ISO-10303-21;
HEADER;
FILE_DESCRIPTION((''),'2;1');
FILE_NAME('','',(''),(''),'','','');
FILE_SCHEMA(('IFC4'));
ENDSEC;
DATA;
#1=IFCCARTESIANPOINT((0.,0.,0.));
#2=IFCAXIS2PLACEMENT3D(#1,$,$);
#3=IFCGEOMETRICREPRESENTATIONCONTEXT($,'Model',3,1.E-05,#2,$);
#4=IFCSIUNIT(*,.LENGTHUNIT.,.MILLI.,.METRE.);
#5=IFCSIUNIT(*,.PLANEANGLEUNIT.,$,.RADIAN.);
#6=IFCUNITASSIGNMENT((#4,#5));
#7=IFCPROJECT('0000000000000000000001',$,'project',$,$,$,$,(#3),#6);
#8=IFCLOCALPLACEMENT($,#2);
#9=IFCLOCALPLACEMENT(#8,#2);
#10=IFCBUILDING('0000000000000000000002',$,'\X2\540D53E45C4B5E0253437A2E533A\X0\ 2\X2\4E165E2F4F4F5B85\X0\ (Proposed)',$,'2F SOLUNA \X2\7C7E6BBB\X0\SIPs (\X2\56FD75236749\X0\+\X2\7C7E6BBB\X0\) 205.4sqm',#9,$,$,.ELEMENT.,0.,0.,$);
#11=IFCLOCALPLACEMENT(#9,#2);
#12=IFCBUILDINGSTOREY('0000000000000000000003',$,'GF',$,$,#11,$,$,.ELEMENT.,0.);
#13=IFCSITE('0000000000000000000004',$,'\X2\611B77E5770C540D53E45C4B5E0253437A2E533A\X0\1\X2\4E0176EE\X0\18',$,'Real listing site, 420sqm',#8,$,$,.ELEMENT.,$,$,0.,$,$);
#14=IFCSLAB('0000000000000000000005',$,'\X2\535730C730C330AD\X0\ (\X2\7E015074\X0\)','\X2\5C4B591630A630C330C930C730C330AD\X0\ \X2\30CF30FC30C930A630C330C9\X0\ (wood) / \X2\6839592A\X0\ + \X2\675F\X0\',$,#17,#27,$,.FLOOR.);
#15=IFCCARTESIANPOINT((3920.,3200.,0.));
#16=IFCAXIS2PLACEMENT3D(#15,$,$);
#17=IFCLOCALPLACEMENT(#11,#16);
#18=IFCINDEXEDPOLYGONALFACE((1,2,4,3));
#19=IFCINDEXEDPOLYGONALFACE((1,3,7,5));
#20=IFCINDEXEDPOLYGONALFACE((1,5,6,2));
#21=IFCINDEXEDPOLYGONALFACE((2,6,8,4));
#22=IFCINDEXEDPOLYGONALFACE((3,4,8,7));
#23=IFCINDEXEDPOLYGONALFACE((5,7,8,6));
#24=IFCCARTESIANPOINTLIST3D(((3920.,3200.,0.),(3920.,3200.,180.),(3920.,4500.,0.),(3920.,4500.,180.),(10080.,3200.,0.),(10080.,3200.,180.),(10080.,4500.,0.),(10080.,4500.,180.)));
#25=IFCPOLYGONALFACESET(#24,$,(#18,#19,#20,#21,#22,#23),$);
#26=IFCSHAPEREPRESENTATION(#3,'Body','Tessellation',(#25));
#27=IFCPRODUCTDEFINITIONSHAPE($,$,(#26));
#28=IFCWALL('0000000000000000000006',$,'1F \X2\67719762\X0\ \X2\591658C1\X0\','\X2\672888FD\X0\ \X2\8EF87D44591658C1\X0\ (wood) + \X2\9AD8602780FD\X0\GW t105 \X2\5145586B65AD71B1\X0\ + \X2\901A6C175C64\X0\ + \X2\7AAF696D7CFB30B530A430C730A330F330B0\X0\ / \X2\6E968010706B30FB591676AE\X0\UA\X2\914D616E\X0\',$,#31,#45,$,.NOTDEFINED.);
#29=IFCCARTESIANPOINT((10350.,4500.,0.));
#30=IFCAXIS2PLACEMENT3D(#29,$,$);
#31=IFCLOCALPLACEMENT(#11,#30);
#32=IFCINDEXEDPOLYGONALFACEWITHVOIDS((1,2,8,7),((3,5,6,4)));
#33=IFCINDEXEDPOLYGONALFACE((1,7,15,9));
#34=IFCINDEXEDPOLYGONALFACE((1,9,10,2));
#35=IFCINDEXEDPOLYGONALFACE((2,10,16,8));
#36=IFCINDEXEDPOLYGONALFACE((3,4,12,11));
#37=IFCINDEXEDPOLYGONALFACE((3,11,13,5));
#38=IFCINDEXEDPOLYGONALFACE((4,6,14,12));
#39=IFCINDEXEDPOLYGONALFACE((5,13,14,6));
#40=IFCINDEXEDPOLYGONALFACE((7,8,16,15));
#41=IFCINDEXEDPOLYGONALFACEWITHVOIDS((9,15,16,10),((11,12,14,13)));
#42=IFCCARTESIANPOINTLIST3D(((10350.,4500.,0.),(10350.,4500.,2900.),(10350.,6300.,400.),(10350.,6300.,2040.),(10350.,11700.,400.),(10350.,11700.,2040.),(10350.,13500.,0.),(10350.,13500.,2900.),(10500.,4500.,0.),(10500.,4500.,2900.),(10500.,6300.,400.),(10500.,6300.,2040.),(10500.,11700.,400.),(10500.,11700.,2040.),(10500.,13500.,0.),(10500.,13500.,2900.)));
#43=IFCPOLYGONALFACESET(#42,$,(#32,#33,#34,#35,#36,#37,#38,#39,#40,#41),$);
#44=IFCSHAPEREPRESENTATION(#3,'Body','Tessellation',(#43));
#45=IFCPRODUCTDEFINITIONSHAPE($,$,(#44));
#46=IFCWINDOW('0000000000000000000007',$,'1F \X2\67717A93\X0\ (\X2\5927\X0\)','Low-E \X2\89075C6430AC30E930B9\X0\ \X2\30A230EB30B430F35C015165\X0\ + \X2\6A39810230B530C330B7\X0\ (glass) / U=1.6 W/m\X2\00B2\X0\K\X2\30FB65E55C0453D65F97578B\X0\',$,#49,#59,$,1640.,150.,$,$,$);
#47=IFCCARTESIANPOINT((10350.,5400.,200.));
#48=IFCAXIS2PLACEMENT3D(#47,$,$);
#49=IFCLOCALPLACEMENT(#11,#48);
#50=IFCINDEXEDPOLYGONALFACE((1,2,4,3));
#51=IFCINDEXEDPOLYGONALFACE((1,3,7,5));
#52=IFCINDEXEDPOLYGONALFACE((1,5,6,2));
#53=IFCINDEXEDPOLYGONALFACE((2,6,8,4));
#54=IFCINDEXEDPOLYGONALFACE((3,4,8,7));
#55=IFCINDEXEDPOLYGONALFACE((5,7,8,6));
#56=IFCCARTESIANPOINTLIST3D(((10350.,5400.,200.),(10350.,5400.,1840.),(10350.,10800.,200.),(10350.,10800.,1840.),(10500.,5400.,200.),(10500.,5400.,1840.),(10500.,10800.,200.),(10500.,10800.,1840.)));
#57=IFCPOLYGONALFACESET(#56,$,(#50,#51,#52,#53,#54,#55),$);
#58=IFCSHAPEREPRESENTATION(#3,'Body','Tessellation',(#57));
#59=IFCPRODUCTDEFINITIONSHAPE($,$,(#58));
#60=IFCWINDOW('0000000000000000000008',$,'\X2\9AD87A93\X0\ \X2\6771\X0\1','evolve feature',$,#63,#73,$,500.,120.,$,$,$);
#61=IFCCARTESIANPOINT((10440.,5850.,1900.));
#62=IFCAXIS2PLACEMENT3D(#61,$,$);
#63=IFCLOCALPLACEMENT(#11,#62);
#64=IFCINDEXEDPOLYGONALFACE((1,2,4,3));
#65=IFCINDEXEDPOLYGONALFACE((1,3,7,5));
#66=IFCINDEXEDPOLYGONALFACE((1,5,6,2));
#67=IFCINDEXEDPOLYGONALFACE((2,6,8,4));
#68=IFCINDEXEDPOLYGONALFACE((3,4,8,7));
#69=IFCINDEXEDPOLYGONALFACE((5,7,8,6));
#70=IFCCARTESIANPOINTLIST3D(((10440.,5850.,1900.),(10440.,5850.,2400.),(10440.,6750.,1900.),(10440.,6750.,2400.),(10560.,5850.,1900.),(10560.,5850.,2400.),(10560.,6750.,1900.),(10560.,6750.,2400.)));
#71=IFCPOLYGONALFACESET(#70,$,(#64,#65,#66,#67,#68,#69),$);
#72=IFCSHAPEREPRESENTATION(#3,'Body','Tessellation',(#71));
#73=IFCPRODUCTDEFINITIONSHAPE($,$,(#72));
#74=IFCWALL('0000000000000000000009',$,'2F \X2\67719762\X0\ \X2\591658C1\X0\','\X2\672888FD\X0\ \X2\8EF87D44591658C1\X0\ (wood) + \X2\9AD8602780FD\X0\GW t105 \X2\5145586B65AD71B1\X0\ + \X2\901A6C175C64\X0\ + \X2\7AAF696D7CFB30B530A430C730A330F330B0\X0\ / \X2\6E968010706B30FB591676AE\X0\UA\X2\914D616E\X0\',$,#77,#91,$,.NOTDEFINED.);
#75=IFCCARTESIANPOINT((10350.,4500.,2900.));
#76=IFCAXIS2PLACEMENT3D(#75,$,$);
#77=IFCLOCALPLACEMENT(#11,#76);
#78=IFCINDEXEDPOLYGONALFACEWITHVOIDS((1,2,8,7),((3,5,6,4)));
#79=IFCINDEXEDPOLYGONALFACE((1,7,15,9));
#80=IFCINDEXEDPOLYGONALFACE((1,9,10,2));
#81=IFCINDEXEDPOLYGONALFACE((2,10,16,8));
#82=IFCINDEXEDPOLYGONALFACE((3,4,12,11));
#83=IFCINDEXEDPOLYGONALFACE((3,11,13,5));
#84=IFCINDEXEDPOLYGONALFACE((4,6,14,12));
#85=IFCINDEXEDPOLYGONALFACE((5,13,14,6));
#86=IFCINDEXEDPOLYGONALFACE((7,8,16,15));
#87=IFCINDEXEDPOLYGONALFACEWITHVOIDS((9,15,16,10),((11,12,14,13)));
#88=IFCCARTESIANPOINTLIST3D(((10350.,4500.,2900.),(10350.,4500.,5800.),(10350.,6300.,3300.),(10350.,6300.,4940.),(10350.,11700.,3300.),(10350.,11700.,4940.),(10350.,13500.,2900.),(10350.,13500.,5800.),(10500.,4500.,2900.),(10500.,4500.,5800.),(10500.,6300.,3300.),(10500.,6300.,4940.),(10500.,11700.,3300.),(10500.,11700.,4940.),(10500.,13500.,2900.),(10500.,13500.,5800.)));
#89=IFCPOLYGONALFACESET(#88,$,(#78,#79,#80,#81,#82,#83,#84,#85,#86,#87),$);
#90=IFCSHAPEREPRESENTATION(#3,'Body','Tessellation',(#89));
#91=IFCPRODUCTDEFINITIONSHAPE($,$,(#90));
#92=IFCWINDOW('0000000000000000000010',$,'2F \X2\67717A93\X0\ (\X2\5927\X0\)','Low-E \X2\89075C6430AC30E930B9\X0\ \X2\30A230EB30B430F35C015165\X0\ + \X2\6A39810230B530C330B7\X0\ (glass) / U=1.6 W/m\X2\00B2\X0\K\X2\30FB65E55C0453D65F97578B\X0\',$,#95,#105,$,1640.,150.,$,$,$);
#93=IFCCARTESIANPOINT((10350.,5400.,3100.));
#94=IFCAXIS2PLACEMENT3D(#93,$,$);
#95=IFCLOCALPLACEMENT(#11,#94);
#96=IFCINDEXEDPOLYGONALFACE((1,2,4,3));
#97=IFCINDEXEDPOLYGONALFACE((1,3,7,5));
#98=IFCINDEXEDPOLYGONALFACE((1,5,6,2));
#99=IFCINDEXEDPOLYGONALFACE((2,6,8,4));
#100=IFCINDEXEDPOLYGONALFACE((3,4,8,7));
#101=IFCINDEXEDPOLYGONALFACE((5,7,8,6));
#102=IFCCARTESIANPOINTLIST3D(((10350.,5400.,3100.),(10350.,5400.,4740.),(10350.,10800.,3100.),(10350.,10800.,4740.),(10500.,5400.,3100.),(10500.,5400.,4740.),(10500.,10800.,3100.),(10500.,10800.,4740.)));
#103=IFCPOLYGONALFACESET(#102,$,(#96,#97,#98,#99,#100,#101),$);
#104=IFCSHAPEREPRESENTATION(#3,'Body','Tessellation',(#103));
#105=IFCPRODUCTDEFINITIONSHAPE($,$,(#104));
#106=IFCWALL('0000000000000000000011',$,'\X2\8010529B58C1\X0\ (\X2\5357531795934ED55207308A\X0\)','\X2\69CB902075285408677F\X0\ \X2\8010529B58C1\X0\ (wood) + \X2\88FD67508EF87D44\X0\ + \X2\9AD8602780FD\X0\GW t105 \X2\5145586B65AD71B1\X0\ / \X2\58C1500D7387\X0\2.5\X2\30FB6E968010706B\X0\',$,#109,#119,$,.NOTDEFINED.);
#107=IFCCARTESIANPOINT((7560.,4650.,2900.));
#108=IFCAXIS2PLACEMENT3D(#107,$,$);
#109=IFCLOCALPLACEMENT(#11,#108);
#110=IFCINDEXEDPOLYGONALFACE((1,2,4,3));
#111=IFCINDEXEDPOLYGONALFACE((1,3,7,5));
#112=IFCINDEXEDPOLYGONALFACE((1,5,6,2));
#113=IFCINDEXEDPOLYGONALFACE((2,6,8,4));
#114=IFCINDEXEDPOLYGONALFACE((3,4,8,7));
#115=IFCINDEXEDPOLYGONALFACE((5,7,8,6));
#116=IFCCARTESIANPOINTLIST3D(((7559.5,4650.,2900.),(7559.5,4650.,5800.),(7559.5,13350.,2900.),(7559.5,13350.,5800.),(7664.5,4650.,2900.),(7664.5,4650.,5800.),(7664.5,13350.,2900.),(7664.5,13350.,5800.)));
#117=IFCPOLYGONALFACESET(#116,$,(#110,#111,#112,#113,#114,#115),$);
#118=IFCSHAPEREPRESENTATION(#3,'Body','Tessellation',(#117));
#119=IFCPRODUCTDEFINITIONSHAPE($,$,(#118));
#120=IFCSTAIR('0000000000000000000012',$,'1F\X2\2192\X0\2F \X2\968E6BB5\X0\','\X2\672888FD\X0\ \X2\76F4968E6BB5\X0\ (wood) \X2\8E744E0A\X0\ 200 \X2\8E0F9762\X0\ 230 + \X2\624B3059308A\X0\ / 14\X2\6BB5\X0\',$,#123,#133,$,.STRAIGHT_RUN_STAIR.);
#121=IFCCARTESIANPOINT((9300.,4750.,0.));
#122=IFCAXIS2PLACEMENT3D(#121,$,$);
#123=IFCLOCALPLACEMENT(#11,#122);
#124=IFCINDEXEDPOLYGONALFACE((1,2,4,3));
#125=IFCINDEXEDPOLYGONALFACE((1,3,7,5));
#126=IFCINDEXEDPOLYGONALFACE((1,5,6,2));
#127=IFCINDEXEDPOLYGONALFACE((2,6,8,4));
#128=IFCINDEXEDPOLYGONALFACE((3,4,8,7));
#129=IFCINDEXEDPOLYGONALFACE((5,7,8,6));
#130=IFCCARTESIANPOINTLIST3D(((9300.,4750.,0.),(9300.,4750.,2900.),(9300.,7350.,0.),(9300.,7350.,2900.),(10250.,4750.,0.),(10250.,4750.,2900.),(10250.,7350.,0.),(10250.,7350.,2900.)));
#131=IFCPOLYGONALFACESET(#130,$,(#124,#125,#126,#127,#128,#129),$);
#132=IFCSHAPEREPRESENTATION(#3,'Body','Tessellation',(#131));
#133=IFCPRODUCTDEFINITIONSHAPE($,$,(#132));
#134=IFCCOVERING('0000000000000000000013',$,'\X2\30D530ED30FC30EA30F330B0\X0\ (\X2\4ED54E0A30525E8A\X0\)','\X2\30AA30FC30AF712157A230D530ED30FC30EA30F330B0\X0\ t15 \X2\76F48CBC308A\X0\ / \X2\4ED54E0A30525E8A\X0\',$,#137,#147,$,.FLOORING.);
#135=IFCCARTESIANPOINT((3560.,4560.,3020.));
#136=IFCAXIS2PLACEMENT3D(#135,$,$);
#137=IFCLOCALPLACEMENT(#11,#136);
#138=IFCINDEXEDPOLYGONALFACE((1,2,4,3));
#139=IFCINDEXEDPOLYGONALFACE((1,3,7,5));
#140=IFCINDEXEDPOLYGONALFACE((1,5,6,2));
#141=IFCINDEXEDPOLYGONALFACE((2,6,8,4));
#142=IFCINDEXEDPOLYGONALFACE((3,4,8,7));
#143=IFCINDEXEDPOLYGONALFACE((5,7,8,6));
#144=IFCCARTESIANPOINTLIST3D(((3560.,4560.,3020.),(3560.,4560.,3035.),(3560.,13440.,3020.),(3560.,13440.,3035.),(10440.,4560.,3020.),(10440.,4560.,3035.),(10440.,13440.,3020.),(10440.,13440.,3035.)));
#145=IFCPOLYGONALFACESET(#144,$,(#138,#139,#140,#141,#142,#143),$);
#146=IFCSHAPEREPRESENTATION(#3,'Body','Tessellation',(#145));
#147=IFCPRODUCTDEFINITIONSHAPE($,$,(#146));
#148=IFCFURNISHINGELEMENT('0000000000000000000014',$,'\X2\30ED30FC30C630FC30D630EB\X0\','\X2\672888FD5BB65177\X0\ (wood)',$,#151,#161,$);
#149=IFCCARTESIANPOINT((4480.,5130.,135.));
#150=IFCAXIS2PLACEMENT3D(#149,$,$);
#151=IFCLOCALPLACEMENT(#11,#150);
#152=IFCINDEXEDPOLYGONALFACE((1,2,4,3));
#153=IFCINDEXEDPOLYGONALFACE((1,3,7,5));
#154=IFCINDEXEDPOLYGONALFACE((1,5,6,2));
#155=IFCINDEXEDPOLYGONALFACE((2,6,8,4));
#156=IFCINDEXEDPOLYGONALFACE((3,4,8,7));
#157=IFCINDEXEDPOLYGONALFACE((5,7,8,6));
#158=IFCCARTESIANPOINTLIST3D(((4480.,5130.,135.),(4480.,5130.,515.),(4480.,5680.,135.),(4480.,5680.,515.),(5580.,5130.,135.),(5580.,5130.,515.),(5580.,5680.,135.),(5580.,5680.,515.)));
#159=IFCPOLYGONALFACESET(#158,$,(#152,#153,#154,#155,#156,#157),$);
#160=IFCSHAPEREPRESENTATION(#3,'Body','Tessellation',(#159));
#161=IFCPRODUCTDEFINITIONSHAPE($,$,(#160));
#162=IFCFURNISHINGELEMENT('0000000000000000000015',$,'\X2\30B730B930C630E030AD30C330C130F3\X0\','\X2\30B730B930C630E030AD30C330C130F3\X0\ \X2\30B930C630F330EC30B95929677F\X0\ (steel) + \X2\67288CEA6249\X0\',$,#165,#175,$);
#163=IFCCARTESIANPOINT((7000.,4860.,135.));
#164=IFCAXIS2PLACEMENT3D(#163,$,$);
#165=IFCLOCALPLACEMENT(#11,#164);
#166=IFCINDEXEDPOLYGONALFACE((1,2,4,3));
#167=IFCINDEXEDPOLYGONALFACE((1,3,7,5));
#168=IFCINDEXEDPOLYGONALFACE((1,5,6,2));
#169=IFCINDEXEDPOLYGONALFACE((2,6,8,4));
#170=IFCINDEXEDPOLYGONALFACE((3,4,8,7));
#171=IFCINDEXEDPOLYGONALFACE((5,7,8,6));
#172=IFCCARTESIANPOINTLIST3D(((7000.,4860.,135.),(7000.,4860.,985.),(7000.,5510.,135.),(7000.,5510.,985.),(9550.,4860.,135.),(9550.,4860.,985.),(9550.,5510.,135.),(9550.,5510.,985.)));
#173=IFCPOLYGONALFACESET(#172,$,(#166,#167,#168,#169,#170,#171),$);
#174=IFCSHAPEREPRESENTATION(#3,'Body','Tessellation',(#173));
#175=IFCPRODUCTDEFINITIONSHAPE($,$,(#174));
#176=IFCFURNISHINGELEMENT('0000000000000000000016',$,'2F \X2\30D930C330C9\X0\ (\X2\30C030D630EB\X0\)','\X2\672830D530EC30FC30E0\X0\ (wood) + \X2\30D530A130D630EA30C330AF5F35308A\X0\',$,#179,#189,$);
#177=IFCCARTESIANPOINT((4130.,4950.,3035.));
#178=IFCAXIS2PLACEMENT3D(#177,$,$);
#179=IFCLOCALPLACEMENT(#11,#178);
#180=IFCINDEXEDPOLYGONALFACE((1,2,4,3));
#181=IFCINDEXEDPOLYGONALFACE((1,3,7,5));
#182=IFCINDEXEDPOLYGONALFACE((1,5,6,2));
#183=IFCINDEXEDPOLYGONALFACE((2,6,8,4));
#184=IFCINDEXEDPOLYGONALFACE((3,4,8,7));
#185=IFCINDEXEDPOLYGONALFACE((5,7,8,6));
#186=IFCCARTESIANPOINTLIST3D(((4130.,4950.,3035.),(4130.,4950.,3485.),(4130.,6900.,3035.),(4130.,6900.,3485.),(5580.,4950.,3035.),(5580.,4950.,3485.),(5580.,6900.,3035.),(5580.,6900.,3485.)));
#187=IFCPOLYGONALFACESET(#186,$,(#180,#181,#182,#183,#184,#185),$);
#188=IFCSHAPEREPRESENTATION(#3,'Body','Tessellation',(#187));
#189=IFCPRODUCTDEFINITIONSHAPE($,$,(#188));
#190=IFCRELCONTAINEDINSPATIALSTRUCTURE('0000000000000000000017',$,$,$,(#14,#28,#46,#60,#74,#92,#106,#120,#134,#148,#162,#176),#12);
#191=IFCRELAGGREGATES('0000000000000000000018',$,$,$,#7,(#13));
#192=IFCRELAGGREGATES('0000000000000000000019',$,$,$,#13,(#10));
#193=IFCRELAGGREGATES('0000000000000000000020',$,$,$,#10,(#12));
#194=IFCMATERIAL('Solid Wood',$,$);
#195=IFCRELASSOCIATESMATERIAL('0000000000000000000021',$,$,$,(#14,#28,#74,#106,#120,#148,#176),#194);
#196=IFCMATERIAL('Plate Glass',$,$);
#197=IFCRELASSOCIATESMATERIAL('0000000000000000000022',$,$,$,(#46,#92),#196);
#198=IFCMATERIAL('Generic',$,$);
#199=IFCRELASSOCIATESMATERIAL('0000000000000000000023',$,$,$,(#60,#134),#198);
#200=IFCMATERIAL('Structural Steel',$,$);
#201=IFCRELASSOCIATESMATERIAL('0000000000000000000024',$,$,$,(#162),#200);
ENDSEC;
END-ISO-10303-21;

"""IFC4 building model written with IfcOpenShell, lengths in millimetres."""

from ifc_helpers import new_model, si_unit, frame, frame_2d, origin, place, context, project, spatial, rectangle, extrude, material, element, fill, save


model = new_model("IFC4")

# Units and contexts
model_context = context("Model", 3, precision=1e-05, world=origin())
ifc_project = project(units=[si_unit("LENGTHUNIT", "METRE", prefix="MILLI"), si_unit("PLANEANGLEUNIT", "RADIAN")], contexts=[model_context])

# Site, building, storey
site_placement = place(None, origin())
site = spatial("IfcSite", under=ifc_project, at=site_placement, Name="愛知県名古屋市千種区1丁目18", ObjectType="Real listing site, 420sqm", CompositionType="ELEMENT", RefElevation=0.0)
building_placement = place(site_placement, origin())
building = spatial("IfcBuilding", under=site, at=building_placement, Name="名古屋市千種区 2世帯住宅 (Proposed)", ObjectType="2F SOLUNA 籾殻SIPs (国産杉+籾殻) 205.4sqm", CompositionType="ELEMENT", ElevationOfRefHeight=0.0, ElevationOfTerrain=0.0)
storey_placement = place(building_placement, origin())
storey = spatial("IfcBuildingStorey", under=building, at=storey_placement, Name="GF", CompositionType="ELEMENT", Elevation=0.0)

# Slab
ifc_material_1 = material(Name="Solid Wood")
slab_placement = place(storey_placement, frame((3920.0, 3200.0, 0.0)))
element("IfcSlab", 1, at=slab_placement, inside=storey, material=ifc_material_1, Name="南デッキ (縁側)", Description="屋外ウッドデッキ ハードウッド (wood) / 根太 + 束", PredefinedType="FLOOR", context=model_context, shape_type="SweptSolid", body=[
    extrude(rectangle(XDim=6160.0, YDim=1300.0, at=frame_2d((3080.0, 650.0))), frame((3920.0, 3200.0, 0.0)), (0.0, 0.0, 1.0), 180.0),
])

# Wall, openings, windows
wall_1_placement = place(storey_placement, frame((10350.0, 4500.0, 0.0)))
wall_1 = element("IfcWall", 2, at=wall_1_placement, inside=storey, material=ifc_material_1, Name="1F 東面 外壁", Description="木製 軸組外壁 (wood) + 高性能GW t105 充填断熱 + 通気層 + 窯業系サイディング / 準耐火・外皮UA配慮", PredefinedType="NOTDEFINED", context=model_context, shape_type="SweptSolid", body=[
    extrude(rectangle(XDim=150.0, YDim=9000.0, at=frame_2d((75.0, 4500.0))), frame((10350.0, 4500.0, 0.0)), (0.0, 0.0, 1.0), 2900.0),
])
opening_1_placement = place(storey_placement, frame((10350.0, 5400.0, 200.0)))
opening_1 = element("IfcOpeningElement", 3, at=opening_1_placement, cuts=wall_1, PredefinedType="NOTDEFINED", context=model_context, shape_type="SweptSolid", body=[
    extrude(rectangle(XDim=150.0, YDim=5400.0, at=frame_2d((75.0, 2700.0))), frame((10350.0, 5400.0, 200.0)), (0.0, 0.0, 1.0), 1640.0),
])
opening_2_placement = place(storey_placement, frame((10440.0, 5850.0, 1900.0)))
opening_2 = element("IfcOpeningElement", 4, at=opening_2_placement, cuts=wall_1, PredefinedType="NOTDEFINED", context=model_context, shape_type="SweptSolid", body=[
    extrude(rectangle(XDim=120.0, YDim=900.0, at=frame_2d((60.0, 450.0))), frame((10440.0, 5850.0, 1900.0)), (0.0, 0.0, 1.0), 500.0),
])
ifc_material_2 = material(Name="Plate Glass")
window_1_placement = place(storey_placement, frame((10350.0, 5400.0, 200.0)))
window_1 = element("IfcWindow", 5, at=window_1_placement, inside=storey, material=ifc_material_2, Name="1F 東窓 (大)", Description="Low-E 複層ガラス アルゴン封入 + 樹脂サッシ (glass) / U=1.6 W/m²K・日射取得型", OverallHeight=1640.0, OverallWidth=150.0, context=model_context, shape_type="SweptSolid", body=[
    extrude(rectangle(XDim=150.0, YDim=5400.0, at=frame_2d((75.0, 2700.0))), frame((10350.0, 5400.0, 200.0)), (0.0, 0.0, 1.0), 1640.0),
])
fill(opening_1, window_1)
ifc_material_3 = material(Name="Generic")
window_2_placement = place(storey_placement, frame((10440.0, 5850.0, 1900.0)))
window_2 = element("IfcWindow", 6, at=window_2_placement, inside=storey, material=ifc_material_3, Name="高窓 東1", Description="evolve feature", OverallHeight=500.0, OverallWidth=120.0, context=model_context, shape_type="SweptSolid", body=[
    extrude(rectangle(XDim=120.0, YDim=900.0, at=frame_2d((60.0, 450.0))), frame((10440.0, 5850.0, 1900.0)), (0.0, 0.0, 1.0), 500.0),
])
fill(opening_2, window_2)

# Wall, opening, window
wall_2_placement = place(storey_placement, frame((10350.0, 4500.0, 2900.0)))
wall_2 = element("IfcWall", 7, at=wall_2_placement, inside=storey, material=ifc_material_1, Name="2F 東面 外壁", Description="木製 軸組外壁 (wood) + 高性能GW t105 充填断熱 + 通気層 + 窯業系サイディング / 準耐火・外皮UA配慮", PredefinedType="NOTDEFINED", context=model_context, shape_type="SweptSolid", body=[
    extrude(rectangle(XDim=150.0, YDim=9000.0, at=frame_2d((75.0, 4500.0))), frame((10350.0, 4500.0, 2900.0)), (0.0, 0.0, 1.0), 2900.0),
])
opening_3_placement = place(storey_placement, frame((10350.0, 5400.0, 3100.0)))
opening_3 = element("IfcOpeningElement", 8, at=opening_3_placement, cuts=wall_2, PredefinedType="NOTDEFINED", context=model_context, shape_type="SweptSolid", body=[
    extrude(rectangle(XDim=150.0, YDim=5400.0, at=frame_2d((75.0, 2700.0))), frame((10350.0, 5400.0, 3100.0)), (0.0, 0.0, 1.0), 1640.0),
])
window_3_placement = place(storey_placement, frame((10350.0, 5400.0, 3100.0)))
window_3 = element("IfcWindow", 9, at=window_3_placement, inside=storey, material=ifc_material_2, Name="2F 東窓 (大)", Description="Low-E 複層ガラス アルゴン封入 + 樹脂サッシ (glass) / U=1.6 W/m²K・日射取得型", OverallHeight=1640.0, OverallWidth=150.0, context=model_context, shape_type="SweptSolid", body=[
    extrude(rectangle(XDim=150.0, YDim=5400.0, at=frame_2d((75.0, 2700.0))), frame((10350.0, 5400.0, 3100.0)), (0.0, 0.0, 1.0), 1640.0),
])
fill(opening_3, window_3)

# Wall
wall_3_placement = place(storey_placement, frame((7560.0, 4650.0, 2900.0)))
element("IfcWall", 10, at=wall_3_placement, inside=storey, material=ifc_material_1, Name="耐力壁 (南北間仕切り)", Description="構造用合板 耐力壁 (wood) + 製材軸組 + 高性能GW t105 充填断熱 / 壁倍率2.5・準耐火", PredefinedType="NOTDEFINED", context=model_context, shape_type="SweptSolid", body=[
    extrude(rectangle(XDim=105.0, YDim=8700.0, at=frame_2d((52.0, 4350.0))), frame((7560.0, 4650.0, 2900.0)), (0.0, 0.0, 1.0), 2900.0),
])

# Stair
stair_placement = place(storey_placement, frame((9300.0, 4750.0, 0.0)))
element("IfcStair", 11, at=stair_placement, inside=storey, material=ifc_material_1, Name="1F→2F 階段", Description="木製 直階段 (wood) 蹴上 200 踏面 230 + 手すり / 14段", PredefinedType="STRAIGHT_RUN_STAIR", context=model_context, shape_type="SweptSolid", body=[
    extrude(rectangle(XDim=950.0, YDim=2600.0, at=frame_2d((475.0, 1300.0))), frame((9300.0, 4750.0, 0.0)), (0.0, 0.0, 1.0), 2900.0),
])

# Covering
covering_placement = place(storey_placement, frame((3560.0, 4560.0, 3020.0)))
element("IfcCovering", 12, at=covering_placement, inside=storey, material=ifc_material_3, Name="フローリング (仕上げ床)", Description="オーク無垢フローリング t15 直貼り / 仕上げ床", PredefinedType="FLOORING", context=model_context, shape_type="SweptSolid", body=[
    extrude(rectangle(XDim=6880.0, YDim=8880.0, at=frame_2d((3440.0, 4440.0))), frame((3560.0, 4560.0, 3020.0)), (0.0, 0.0, 1.0), 15.0),
])

# Furnishing elements
furnishing_1_placement = place(storey_placement, frame((4480.0, 5130.0, 135.0)))
element("IfcFurnishingElement", 13, at=furnishing_1_placement, inside=storey, material=ifc_material_1, Name="ローテーブル", Description="木製家具 (wood)", context=model_context, shape_type="SweptSolid", body=[
    extrude(rectangle(XDim=1100.0, YDim=550.0, at=frame_2d((550.0, 275.0))), frame((4480.0, 5130.0, 135.0)), (0.0, 0.0, 1.0), 380.0),
])
ifc_material_4 = material(Name="Structural Steel")
furnishing_2_placement = place(storey_placement, frame((7000.0, 4860.0, 135.0)))
element("IfcFurnishingElement", 14, at=furnishing_2_placement, inside=storey, material=ifc_material_4, Name="システムキッチン", Description="システムキッチン ステンレス天板 (steel) + 木質扉", context=model_context, shape_type="SweptSolid", body=[
    extrude(rectangle(XDim=2550.0, YDim=650.0, at=frame_2d((1275.0, 325.0))), frame((7000.0, 4860.0, 135.0)), (0.0, 0.0, 1.0), 850.0),
])
furnishing_3_placement = place(storey_placement, frame((4130.0, 4950.0, 3035.0)))
element("IfcFurnishingElement", 15, at=furnishing_3_placement, inside=storey, material=ifc_material_1, Name="2F ベッド (ダブル)", Description="木フレーム (wood) + ファブリック張り", context=model_context, shape_type="SweptSolid", body=[
    extrude(rectangle(XDim=1450.0, YDim=1950.0, at=frame_2d((725.0, 975.0))), frame((4130.0, 4950.0, 3035.0)), (0.0, 0.0, 1.0), 450.0),
])

save(model, "model.ifc")
